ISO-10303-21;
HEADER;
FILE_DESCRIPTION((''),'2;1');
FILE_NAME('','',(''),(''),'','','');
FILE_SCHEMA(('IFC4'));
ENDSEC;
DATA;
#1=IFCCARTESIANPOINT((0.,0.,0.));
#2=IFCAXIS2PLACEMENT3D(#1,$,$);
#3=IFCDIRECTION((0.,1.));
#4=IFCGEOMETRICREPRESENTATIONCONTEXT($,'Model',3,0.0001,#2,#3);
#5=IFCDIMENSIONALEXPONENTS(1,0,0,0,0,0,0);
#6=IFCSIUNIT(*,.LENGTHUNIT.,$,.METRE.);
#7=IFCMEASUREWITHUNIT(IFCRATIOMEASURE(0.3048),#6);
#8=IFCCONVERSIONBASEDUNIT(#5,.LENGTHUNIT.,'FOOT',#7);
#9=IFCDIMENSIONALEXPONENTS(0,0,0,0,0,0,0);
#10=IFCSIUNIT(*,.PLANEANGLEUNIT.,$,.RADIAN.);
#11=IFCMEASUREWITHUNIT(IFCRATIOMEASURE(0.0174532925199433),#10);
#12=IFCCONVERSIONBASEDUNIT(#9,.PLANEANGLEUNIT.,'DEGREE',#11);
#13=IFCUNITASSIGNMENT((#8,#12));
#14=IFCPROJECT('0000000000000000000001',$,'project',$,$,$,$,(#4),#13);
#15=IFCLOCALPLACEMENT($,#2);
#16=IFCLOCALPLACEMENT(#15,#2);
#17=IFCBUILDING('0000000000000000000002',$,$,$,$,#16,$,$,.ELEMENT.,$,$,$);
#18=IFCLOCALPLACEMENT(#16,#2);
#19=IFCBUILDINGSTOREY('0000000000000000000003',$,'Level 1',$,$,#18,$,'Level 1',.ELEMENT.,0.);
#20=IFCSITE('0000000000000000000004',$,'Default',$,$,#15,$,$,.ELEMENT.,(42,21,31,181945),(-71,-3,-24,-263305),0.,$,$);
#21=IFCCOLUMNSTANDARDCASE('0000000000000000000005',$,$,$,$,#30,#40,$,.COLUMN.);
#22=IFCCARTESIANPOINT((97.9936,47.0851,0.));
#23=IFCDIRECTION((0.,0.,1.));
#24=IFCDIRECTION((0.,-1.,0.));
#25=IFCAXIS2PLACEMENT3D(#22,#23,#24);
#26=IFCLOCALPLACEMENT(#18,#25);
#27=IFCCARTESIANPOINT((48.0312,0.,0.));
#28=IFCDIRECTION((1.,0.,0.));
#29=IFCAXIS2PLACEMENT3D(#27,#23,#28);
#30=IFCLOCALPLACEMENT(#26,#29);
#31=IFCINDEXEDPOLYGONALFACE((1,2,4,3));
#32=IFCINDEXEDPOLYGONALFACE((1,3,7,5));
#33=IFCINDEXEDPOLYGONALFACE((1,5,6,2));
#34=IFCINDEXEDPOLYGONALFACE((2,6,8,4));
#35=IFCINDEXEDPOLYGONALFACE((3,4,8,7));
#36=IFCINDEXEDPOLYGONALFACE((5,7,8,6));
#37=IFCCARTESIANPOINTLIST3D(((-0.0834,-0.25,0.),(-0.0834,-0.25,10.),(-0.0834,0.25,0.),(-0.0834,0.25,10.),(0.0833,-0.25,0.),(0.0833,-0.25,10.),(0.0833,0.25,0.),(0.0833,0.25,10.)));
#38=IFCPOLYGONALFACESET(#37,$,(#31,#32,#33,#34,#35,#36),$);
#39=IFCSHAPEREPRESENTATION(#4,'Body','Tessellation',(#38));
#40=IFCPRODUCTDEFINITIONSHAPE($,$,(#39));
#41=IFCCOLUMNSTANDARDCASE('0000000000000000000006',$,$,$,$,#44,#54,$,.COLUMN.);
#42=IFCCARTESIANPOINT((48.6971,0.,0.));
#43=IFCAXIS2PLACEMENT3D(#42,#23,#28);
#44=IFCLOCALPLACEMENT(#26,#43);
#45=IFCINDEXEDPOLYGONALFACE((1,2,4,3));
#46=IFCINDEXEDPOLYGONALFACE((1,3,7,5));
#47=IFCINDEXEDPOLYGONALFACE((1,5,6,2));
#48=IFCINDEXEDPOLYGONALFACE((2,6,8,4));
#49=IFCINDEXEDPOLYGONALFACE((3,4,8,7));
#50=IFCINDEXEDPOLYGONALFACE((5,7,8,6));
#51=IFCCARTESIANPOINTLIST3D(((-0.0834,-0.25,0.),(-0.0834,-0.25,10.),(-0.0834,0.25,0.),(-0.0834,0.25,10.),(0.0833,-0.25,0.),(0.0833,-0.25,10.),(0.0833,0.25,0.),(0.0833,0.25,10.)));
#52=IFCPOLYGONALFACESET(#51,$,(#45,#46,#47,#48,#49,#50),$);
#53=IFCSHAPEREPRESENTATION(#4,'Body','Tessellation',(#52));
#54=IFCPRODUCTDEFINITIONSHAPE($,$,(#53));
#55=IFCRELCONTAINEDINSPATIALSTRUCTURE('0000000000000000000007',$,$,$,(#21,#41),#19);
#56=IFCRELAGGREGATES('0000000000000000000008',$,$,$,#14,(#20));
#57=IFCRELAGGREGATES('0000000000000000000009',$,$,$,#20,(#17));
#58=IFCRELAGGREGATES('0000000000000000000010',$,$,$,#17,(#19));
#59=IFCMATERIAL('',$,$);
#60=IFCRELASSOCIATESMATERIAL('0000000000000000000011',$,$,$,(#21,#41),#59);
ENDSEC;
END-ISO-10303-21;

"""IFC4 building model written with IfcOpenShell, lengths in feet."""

from ifc_helpers import new_model, entity, si_unit, converted_unit, direction, frame, origin, place, context, project, spatial, rectangle, extrude, material, element, save


model = new_model("IFC4")

# Units and contexts
model_context = context("Model", 3, precision=0.0001, world=origin(), true_north=direction((0.0, 1.0)))
ifc_project = project(units=[converted_unit("LENGTHUNIT", "FOOT", entity("IfcRatioMeasure", 0.3048), si_unit("LENGTHUNIT", "METRE"), dimensions=[1, 0, 0, 0, 0, 0, 0]), converted_unit("PLANEANGLEUNIT", "DEGREE", entity("IfcRatioMeasure", 0.0174532925199433), si_unit("PLANEANGLEUNIT", "RADIAN"), dimensions=[0, 0, 0, 0, 0, 0, 0])], contexts=[model_context])

# Site, building, storey
site_placement = place(None, origin())
site = spatial("IfcSite", under=ifc_project, at=site_placement, Name="Default", CompositionType="ELEMENT", RefLatitude=(42, 21, 31, 181945), RefLongitude=(-71, -3, -24, -263305), RefElevation=0.0)
building_placement = place(site_placement, origin())
building = spatial("IfcBuilding", under=site, at=building_placement, CompositionType="ELEMENT")
storey_placement = place(building_placement, origin())
storey = spatial("IfcBuildingStorey", under=building, at=storey_placement, Name="Level 1", LongName="Level 1", CompositionType="ELEMENT", Elevation=0.0)

# Columns
ifc_material_1 = material(Name="")
placement = place(storey_placement, frame((97.9936, 47.0851, 0.0), z_axis=(0.0, 0.0, 1.0), x_axis=(0.0, -1.0, 0.0)))
for number, where, z_axis, x_axis in (
    (1, (48.0312, 0.0, 0.0), (0.0, 0.0, 1.0), (1.0, 0.0, 0.0)),
    (2, (48.6971, 0.0, 0.0), (0.0, 0.0, 1.0), (1.0, 0.0, 0.0)),
):
    element("IfcColumnStandardCase", number, at=place(placement, frame(where, z_axis=z_axis, x_axis=x_axis)), inside=storey, material=ifc_material_1, PredefinedType="COLUMN", context=model_context, shape_type="SweptSolid", body=[
        extrude(rectangle(XDim=0.1667, YDim=0.5), origin(), (0.0, 0.0, 1.0), 10.0),
    ])

save(model, "model.ifc")
